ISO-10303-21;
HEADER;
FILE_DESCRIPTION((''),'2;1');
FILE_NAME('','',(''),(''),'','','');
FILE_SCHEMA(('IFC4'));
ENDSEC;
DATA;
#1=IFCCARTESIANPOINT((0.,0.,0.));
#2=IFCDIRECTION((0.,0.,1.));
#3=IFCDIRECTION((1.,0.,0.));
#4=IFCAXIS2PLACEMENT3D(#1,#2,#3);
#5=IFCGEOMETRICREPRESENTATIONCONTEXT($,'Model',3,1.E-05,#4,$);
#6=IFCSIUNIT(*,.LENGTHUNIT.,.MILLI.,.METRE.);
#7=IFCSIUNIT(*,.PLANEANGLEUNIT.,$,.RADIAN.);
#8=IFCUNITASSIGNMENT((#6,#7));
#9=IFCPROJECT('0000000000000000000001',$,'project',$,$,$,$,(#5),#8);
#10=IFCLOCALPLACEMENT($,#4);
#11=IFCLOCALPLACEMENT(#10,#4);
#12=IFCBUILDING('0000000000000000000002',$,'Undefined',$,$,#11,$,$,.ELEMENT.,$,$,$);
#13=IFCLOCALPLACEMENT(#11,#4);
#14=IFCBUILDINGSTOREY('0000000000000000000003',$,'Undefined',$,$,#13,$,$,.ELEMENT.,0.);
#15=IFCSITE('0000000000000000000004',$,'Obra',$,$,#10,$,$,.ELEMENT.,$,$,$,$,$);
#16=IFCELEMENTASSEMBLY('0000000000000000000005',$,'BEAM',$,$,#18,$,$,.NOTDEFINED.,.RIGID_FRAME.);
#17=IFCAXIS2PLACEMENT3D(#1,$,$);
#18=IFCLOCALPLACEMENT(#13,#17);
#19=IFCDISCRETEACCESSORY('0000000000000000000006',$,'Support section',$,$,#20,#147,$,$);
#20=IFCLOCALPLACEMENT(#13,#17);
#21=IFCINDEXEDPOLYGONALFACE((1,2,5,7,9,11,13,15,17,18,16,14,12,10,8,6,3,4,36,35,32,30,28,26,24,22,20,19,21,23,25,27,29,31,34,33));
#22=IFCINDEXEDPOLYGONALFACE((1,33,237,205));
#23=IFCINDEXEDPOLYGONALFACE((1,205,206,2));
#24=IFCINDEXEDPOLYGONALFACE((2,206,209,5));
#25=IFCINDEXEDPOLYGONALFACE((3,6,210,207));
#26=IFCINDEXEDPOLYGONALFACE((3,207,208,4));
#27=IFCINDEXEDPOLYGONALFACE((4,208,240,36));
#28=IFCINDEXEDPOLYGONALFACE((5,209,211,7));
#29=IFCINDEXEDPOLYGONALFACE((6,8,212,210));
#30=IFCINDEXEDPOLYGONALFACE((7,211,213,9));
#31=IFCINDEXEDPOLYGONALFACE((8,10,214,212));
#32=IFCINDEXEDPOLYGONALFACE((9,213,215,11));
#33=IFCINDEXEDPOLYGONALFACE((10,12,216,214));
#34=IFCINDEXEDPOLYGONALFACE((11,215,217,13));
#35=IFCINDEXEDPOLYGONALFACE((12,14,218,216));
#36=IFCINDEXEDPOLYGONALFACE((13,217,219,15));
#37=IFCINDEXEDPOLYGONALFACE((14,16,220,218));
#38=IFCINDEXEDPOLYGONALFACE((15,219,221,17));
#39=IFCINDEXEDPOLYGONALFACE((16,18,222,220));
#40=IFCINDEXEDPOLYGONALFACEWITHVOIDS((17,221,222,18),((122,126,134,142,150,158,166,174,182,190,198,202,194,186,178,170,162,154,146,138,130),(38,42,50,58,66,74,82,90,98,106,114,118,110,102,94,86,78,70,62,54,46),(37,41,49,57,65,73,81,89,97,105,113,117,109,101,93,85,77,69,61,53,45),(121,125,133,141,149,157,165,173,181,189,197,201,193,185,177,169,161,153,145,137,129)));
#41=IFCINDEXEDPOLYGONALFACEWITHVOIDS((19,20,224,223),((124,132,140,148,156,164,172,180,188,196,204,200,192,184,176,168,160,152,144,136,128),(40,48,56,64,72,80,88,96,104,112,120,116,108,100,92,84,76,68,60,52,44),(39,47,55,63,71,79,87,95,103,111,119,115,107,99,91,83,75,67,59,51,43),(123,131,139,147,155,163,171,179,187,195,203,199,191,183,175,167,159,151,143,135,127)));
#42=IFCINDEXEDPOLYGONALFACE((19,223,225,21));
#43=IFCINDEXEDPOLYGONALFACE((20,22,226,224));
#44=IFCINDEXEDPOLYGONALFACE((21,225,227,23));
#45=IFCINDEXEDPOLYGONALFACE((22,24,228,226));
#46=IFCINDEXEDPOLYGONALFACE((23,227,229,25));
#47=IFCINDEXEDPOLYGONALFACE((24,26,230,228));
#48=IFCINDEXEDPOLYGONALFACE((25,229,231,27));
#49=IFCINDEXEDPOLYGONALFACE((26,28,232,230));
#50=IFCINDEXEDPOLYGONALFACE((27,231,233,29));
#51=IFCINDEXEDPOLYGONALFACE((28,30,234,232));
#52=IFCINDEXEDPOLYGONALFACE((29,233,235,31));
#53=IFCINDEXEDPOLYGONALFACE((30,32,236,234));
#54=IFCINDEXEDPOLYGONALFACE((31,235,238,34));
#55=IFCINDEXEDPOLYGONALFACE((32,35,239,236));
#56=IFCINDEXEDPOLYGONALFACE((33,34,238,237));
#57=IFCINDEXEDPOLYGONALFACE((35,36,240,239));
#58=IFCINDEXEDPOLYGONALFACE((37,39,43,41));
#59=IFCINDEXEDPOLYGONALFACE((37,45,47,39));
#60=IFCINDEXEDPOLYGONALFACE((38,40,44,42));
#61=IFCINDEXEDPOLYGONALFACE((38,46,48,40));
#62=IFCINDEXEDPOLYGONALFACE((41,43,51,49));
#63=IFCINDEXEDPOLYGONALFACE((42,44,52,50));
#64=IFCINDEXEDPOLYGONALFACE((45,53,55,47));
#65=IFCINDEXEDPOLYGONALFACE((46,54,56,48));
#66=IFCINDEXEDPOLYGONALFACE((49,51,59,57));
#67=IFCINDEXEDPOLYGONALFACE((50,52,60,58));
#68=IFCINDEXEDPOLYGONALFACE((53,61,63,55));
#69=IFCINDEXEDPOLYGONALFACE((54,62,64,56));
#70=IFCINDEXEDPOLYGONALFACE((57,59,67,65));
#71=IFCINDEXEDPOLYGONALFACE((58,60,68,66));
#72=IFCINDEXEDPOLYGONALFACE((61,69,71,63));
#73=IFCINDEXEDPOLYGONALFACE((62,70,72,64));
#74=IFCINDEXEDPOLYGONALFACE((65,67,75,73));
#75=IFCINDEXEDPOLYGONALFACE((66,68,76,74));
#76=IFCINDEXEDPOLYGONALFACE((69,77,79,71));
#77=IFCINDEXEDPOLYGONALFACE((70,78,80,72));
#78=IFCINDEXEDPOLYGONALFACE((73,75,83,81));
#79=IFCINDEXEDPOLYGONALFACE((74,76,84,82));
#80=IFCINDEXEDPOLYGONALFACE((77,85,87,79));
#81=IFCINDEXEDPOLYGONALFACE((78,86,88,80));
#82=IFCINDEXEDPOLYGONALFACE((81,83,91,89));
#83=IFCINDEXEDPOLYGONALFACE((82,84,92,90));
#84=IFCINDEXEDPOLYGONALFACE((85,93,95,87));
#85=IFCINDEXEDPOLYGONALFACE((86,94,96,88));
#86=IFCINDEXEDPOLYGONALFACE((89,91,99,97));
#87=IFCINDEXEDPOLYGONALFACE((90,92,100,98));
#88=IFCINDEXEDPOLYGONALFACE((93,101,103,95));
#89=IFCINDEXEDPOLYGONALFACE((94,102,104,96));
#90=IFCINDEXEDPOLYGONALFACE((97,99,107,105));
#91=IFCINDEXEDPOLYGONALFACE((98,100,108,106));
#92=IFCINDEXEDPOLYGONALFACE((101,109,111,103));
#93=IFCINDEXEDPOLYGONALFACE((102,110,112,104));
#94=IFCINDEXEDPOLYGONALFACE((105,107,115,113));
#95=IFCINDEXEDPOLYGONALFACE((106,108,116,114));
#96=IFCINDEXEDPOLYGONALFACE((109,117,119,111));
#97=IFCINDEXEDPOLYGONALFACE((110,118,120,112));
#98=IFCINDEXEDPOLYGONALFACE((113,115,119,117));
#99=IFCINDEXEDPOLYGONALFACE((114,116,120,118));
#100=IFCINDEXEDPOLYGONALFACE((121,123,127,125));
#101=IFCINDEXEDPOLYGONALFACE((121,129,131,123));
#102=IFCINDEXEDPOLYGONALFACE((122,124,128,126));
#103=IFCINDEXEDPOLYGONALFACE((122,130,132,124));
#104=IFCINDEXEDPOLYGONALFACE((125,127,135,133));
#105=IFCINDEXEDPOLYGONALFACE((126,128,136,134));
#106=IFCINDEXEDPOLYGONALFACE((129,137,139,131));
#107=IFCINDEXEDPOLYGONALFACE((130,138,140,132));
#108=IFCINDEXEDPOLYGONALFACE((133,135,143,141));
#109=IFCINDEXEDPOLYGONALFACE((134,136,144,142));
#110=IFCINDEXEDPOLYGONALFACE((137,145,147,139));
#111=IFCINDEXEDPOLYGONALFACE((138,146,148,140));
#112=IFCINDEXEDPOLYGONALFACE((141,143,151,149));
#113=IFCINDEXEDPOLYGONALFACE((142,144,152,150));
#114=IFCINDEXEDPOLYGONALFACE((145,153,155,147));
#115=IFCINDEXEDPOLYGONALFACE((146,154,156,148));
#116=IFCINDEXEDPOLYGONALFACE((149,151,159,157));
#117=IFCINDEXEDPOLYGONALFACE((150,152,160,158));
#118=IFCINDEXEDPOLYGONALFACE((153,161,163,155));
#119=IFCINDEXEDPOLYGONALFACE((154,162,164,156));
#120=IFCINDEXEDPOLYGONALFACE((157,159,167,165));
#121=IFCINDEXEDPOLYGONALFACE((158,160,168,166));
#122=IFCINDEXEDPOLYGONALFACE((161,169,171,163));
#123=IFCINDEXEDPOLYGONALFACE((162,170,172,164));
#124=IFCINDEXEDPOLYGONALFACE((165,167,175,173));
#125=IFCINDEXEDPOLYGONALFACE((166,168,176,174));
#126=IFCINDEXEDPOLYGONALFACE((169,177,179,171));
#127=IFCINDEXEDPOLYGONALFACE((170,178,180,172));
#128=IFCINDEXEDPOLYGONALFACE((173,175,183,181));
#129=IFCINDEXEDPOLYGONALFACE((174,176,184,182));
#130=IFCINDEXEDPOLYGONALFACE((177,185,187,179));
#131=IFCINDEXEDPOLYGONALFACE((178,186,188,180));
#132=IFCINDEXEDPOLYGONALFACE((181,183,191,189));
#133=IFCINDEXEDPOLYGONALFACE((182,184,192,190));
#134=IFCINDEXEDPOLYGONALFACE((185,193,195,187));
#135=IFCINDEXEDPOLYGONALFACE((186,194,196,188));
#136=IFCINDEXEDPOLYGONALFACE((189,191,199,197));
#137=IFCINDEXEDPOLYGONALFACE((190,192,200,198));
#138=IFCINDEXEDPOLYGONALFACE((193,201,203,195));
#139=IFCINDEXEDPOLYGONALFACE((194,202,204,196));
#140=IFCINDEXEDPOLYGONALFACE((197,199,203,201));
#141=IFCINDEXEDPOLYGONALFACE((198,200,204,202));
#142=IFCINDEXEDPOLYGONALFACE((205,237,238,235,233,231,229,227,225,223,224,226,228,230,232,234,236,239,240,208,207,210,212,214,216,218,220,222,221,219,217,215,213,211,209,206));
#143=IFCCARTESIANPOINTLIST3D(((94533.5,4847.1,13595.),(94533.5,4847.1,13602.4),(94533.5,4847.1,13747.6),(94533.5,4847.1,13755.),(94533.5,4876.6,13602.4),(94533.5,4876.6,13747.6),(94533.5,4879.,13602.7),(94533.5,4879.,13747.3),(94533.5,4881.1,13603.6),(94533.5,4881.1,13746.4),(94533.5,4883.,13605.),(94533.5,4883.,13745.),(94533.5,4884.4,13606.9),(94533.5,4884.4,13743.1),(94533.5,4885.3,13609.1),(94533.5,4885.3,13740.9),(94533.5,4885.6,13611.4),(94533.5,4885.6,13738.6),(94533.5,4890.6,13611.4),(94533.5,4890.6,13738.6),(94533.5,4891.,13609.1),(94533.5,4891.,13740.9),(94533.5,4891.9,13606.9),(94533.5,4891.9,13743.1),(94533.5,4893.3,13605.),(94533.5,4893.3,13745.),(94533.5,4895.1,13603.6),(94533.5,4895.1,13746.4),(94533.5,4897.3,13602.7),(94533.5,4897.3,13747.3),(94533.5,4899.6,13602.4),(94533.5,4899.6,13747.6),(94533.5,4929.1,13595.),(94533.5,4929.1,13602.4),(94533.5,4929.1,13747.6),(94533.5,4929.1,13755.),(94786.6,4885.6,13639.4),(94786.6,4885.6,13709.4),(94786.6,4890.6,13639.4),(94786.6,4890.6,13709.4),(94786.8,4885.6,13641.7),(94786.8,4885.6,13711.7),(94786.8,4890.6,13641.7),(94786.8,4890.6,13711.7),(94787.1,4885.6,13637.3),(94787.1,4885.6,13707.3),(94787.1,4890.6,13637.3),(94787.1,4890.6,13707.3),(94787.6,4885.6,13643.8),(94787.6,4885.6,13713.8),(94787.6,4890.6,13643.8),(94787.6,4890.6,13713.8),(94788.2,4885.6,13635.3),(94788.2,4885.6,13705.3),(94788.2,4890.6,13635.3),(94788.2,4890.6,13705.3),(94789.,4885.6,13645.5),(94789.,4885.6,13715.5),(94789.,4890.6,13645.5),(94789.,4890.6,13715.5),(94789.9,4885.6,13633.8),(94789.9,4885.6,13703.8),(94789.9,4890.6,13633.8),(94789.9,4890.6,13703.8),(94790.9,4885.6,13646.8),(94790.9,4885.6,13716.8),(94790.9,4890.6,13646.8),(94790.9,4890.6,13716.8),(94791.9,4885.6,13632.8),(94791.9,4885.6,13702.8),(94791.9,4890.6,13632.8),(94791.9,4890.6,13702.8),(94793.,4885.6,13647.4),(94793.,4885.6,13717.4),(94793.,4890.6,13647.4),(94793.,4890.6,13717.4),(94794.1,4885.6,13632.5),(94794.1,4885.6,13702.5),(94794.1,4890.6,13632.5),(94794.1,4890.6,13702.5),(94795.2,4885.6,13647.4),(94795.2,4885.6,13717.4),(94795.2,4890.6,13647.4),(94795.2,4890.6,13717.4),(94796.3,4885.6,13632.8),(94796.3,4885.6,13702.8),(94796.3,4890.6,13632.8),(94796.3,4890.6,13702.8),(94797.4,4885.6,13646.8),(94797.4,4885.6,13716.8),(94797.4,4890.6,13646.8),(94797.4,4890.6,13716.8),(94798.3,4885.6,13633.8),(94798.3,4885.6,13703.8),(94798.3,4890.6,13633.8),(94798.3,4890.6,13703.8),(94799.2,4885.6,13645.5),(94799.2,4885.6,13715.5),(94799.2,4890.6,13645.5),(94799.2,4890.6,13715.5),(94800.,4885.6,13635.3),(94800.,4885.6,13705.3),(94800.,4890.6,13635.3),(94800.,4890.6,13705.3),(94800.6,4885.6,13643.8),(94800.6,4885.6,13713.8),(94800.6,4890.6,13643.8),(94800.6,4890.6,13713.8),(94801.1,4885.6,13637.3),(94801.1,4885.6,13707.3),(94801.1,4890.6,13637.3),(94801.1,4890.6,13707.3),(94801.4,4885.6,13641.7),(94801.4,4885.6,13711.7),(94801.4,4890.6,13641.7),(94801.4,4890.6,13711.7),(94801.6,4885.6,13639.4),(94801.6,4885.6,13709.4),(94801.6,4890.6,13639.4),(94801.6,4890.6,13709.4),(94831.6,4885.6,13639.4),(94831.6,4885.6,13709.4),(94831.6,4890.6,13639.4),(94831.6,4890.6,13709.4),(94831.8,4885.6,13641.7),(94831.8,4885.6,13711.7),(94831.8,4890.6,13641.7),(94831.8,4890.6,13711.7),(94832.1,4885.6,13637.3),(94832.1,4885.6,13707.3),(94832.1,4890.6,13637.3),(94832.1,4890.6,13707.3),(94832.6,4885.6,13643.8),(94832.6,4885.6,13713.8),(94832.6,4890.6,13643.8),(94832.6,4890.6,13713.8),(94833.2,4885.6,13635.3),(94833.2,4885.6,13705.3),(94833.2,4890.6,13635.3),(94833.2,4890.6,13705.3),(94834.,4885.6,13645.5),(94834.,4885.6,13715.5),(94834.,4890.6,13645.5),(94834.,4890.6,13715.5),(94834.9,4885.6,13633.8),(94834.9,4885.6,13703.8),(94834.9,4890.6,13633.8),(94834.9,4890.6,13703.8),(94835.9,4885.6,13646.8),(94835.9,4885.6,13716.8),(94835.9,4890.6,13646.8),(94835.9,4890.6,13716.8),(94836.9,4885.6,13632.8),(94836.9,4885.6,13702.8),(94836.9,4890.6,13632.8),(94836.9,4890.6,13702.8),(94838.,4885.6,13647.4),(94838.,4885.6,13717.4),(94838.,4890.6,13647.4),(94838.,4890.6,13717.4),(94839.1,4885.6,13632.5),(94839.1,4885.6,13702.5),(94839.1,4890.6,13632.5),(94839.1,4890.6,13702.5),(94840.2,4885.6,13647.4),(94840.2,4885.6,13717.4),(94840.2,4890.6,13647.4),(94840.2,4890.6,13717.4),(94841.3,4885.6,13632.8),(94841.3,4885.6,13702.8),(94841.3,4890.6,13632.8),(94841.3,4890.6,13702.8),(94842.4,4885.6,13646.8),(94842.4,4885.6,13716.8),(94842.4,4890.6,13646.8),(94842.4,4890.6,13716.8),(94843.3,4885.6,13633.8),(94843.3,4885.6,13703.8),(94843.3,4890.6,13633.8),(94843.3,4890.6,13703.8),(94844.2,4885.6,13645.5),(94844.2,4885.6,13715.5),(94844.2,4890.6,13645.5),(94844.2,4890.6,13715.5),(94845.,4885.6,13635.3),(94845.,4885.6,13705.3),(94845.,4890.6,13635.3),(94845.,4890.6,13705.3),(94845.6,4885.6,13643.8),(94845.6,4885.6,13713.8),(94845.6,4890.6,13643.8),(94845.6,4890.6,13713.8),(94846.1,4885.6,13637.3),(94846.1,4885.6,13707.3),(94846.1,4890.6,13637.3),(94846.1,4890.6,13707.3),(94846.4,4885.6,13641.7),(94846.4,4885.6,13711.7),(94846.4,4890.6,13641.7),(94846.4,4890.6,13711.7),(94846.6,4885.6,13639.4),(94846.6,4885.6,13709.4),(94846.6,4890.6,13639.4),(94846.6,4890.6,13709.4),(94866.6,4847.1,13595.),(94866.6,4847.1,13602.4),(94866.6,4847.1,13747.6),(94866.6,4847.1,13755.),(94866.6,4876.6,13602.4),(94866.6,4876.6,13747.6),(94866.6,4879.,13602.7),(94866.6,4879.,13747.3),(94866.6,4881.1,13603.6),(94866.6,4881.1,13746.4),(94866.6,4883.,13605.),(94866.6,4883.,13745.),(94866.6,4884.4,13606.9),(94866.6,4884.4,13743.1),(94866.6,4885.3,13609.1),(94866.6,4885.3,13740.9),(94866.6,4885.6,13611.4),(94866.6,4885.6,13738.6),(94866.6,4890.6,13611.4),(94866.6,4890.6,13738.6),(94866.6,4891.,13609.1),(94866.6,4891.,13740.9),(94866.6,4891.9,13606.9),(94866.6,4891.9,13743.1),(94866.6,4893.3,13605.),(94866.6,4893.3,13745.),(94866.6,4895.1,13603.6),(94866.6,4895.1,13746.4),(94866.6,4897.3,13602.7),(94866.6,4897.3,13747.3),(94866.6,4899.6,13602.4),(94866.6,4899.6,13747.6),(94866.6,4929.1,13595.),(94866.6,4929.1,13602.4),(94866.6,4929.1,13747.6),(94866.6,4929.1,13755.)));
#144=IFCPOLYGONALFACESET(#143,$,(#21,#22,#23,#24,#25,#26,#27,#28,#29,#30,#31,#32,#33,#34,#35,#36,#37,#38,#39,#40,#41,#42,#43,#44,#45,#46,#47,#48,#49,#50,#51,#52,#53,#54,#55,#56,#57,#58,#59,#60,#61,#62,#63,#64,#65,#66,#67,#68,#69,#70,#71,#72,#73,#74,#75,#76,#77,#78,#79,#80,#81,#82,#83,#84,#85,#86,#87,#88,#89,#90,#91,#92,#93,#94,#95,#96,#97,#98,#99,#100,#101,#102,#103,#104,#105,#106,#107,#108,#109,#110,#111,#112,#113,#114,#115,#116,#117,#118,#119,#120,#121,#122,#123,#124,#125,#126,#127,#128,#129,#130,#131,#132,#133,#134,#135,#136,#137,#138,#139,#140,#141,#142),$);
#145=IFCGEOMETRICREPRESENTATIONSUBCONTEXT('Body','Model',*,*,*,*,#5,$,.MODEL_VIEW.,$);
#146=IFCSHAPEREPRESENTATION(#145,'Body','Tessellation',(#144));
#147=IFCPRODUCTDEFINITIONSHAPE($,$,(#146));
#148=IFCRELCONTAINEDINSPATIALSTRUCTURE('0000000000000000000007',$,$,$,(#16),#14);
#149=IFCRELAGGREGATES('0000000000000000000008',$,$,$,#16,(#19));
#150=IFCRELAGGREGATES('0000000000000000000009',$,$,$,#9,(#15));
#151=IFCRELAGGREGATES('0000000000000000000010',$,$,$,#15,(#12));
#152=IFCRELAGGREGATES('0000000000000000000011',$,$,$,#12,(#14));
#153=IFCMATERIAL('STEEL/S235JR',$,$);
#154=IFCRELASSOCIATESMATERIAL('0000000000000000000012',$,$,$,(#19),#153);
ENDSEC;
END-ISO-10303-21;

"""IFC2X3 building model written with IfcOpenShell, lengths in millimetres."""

from ifc_helpers import new_model, si_unit, frame, origin_with_axes, origin_2d_with_axis, place, context, subcontext, project, spatial, circle, i_section, extrude, clip, halfspace, source, transform, mapped, material, element, aggregate, save


model = new_model("IFC2X3")

# Units and contexts
model_context = context("Model", 3, precision=1e-05, world=origin_with_axes())
body_context = subcontext(model_context, "Body", "Model", "MODEL_VIEW")
ifc_project = project(units=[si_unit("LENGTHUNIT", "METRE", prefix="MILLI"), si_unit("PLANEANGLEUNIT", "RADIAN")], contexts=[model_context])

# Site, building, storey
site_placement = place(None, origin_with_axes())
site = spatial("IfcSite", under=ifc_project, at=site_placement, Name="Obra", CompositionType="ELEMENT")
building_placement = place(site_placement, origin_with_axes())
building = spatial("IfcBuilding", under=site, at=building_placement, Name="Undefined", CompositionType="ELEMENT")
storey_placement = place(building_placement, origin_with_axes())
storey = spatial("IfcBuildingStorey", under=building, at=storey_placement, Name="Undefined", CompositionType="ELEMENT", Elevation=0.0)

# Shared definitions
ifc_material_1 = material(Name="STEEL/S235JR")

# Element assembly
assembly_1_placement = place(storey_placement, origin_with_axes())
assembly_1 = element("IfcElementAssembly", 1, at=assembly_1_placement, inside=storey, Name="BEAM", AssemblyPlace="NOTDEFINED", PredefinedType="RIGID_FRAME")

# Discrete accessory, opening
shared_shape_1 = source(origin_with_axes(), body_context, "Body", "SweptSolid", [
    extrude(circle(Radius=7.5, at=origin_2d_with_axis()), frame((0.0, -2.6, 0.0), z_axis=(0.0, 1.0, 0.0), x_axis=(1.0, 0.0, 0.0)), (0.0, 0.0, 1.0), 5.2),
])
discrete_accessory_1_placement = place(assembly_1_placement, frame((94533.5, 4888.1, 13675.0), z_axis=(0.0, 0.0, 1.0), x_axis=(1.0, 0.0, 0.0)))
discrete_accessory_1 = element("IfcDiscreteAccessory", 2, at=discrete_accessory_1_placement, material=ifc_material_1, Name="Support section", context=body_context, shape_type="Clipping", body=[
    clip(extrude(i_section(OverallWidth=82.0, OverallDepth=160.0, WebThickness=5.0, FlangeThickness=7.4, FilletRadius=9.0, at=origin_2d_with_axis()), frame((333.1, 0.0, 0.0), z_axis=(-1.0, 0.0, 0.0), x_axis=(0.0, -1.0, 0.0)), (0.0, 0.0, 1.0), 333.1), halfspace(frame((333.1, 0.0, -180.0), z_axis=(-1.0, 0.0, 0.0), x_axis=(0.0, 1.0, 0.0)), True)),
])
opening_1_placement = place(assembly_1_placement, frame((94816.6, 4888.1, 13710.0), z_axis=(-1.0, 0.0, 0.0), x_axis=(0.0, 0.0, -1.0)))
element("IfcOpeningElement", 3, at=opening_1_placement, cuts=discrete_accessory_1, ObjectType="Opening", context=body_context, shape_type="MappedRepresentation", body=[
    mapped(shared_shape_1, transform((0.0, 0.0, -22.5))),
    mapped(shared_shape_1, transform((70.0, 0.0, -22.5))),
    mapped(shared_shape_1, transform((0.0, 0.0, 22.5))),
    mapped(shared_shape_1, transform((70.0, 0.0, 22.5))),
])
aggregate(assembly_1, [discrete_accessory_1])

save(model, "model.ifc")
